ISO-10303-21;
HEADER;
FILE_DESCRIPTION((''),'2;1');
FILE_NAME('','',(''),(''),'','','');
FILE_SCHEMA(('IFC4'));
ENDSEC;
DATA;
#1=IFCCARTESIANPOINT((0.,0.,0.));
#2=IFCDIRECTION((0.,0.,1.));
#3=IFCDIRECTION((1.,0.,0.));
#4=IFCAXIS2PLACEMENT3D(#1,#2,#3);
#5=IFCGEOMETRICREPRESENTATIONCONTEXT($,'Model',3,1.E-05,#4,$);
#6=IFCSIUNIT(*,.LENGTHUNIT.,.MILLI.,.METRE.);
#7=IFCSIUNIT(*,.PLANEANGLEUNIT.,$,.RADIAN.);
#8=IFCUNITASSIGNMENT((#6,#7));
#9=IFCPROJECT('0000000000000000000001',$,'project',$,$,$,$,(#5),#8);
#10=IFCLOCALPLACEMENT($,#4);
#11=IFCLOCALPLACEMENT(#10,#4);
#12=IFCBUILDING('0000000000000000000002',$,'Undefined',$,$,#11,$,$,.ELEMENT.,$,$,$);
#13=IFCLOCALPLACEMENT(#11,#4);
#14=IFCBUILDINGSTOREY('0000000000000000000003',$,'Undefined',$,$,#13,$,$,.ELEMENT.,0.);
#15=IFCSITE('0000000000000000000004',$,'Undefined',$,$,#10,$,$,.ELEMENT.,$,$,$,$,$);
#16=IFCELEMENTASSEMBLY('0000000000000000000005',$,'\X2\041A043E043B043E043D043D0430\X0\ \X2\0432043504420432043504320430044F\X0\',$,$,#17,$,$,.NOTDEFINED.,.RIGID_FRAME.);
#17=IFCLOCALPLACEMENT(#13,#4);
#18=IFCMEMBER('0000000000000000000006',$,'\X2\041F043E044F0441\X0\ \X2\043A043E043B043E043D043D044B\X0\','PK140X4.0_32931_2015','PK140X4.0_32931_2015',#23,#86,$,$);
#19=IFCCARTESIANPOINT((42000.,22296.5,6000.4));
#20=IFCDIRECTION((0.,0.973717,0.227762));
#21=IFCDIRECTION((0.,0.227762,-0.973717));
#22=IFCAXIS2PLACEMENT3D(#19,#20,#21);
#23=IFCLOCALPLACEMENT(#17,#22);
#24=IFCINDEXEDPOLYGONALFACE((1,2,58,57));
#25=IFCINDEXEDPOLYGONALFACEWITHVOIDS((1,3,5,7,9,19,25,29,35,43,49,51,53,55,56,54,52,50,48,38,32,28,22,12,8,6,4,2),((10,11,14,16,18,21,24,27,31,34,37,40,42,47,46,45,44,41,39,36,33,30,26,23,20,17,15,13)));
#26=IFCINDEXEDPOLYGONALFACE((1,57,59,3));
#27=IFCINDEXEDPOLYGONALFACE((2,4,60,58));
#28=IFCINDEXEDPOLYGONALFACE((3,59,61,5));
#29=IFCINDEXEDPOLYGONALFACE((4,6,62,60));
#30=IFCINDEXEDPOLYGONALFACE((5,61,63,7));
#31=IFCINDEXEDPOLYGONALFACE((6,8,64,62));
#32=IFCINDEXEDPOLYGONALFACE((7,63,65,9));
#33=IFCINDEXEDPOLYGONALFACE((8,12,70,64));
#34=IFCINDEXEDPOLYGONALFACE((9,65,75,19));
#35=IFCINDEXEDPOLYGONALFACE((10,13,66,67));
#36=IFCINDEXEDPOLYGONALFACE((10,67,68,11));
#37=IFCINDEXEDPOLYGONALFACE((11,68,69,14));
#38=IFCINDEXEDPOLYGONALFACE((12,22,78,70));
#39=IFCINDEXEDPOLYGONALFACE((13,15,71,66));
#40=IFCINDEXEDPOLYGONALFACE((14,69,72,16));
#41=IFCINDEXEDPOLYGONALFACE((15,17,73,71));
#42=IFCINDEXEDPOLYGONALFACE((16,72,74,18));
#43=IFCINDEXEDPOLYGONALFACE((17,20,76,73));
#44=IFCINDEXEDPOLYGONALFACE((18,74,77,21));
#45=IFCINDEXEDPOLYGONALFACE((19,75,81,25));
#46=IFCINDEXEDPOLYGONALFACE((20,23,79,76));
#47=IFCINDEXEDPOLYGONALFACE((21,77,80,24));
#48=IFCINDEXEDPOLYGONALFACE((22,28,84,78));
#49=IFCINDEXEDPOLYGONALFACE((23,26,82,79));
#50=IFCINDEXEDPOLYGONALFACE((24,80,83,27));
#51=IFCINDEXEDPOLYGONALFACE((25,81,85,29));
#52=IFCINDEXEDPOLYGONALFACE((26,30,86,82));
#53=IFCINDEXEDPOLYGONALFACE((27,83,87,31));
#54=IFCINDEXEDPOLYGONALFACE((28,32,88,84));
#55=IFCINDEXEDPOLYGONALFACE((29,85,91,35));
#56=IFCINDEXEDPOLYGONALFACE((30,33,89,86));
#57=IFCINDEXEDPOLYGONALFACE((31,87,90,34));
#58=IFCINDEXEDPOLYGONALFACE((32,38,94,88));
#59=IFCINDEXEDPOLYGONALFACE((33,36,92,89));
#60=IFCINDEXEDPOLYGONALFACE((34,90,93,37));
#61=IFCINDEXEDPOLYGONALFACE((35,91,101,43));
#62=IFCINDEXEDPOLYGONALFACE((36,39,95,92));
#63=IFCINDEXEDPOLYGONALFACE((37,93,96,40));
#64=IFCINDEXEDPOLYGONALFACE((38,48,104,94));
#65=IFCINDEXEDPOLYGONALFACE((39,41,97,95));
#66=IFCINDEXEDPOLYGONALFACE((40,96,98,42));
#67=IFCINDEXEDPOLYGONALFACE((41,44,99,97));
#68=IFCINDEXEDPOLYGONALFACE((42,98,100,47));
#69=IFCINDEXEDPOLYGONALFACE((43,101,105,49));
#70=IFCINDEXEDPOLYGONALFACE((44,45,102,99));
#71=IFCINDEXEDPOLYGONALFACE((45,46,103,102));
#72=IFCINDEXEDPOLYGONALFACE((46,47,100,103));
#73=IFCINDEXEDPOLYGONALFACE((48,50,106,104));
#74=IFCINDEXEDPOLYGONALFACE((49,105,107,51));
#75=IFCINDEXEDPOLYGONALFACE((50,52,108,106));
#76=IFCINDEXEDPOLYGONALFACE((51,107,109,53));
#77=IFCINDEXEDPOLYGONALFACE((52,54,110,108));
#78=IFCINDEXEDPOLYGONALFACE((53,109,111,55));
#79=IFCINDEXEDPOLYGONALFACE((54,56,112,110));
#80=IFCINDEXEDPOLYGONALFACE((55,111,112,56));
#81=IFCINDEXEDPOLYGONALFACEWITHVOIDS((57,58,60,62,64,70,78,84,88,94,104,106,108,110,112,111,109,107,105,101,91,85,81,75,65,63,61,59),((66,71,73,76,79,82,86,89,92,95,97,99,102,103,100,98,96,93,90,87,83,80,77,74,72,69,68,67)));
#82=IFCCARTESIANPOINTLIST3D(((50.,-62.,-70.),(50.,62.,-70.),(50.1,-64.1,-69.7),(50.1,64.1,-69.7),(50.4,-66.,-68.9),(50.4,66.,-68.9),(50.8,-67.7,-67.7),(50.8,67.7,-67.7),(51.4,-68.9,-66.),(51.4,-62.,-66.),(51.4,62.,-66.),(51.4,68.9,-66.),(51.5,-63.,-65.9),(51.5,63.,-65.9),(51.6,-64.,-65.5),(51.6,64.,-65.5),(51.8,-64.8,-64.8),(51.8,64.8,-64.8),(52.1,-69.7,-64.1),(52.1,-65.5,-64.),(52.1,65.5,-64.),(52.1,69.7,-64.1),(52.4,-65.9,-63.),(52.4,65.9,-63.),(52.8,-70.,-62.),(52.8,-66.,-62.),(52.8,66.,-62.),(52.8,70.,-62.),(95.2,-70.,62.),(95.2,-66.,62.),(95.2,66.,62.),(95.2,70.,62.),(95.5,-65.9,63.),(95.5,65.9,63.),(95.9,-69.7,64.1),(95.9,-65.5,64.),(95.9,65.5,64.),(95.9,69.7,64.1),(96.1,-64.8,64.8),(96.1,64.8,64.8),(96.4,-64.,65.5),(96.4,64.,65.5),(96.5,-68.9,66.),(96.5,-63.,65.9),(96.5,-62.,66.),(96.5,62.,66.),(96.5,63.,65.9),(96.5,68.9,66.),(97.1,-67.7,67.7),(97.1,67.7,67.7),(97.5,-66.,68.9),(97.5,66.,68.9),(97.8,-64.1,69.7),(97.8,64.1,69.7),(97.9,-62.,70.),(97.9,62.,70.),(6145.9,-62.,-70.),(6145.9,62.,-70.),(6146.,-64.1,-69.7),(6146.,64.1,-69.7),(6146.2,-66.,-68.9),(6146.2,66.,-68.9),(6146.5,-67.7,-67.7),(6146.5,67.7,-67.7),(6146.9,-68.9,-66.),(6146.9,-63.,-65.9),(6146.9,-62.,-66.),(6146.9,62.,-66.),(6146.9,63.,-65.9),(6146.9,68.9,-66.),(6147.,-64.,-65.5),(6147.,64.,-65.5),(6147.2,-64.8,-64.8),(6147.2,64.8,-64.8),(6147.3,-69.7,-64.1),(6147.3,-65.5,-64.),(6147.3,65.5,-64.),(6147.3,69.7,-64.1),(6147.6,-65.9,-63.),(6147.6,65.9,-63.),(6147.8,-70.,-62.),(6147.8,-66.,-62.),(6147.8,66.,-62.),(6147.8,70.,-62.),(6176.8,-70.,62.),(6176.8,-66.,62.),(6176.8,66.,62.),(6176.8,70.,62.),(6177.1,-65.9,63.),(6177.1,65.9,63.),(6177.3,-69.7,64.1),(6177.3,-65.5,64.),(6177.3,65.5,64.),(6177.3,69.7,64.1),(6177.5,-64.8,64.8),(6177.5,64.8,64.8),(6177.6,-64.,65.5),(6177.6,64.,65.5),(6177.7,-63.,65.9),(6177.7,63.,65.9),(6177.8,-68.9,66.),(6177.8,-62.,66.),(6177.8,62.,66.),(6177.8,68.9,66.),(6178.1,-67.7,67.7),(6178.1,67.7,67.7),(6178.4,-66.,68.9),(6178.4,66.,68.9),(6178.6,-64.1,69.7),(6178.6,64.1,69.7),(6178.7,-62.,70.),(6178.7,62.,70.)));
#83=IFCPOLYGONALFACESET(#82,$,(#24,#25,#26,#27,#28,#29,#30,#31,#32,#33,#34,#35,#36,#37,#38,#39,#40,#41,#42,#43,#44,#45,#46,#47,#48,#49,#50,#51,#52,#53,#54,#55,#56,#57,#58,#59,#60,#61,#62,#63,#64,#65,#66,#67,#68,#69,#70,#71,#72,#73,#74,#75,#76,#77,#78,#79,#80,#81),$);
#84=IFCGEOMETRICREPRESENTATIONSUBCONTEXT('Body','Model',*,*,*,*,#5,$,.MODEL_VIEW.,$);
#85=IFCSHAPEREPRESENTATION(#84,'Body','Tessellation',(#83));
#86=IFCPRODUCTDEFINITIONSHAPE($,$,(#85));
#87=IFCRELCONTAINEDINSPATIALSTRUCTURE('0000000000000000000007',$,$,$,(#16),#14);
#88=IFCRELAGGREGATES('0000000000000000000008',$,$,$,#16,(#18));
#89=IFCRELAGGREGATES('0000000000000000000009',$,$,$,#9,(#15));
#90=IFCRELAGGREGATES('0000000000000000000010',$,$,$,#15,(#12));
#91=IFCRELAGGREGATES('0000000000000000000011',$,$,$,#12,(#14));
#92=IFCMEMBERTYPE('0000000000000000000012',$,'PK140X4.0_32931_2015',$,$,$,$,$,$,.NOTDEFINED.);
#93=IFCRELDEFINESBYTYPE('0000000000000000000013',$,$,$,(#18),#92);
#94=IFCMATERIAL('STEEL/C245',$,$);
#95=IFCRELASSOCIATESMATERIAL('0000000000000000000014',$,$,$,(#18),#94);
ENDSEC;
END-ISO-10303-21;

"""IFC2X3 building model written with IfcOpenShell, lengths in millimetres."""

from ifc_helpers import new_model, si_unit, frame, origin_with_axes, origin_2d_with_axis, place, context, subcontext, project, spatial, hollow_rectangle, extrude, clip, halfspace, material, type_object, element, aggregate, save


model = new_model("IFC2X3")

# Units and contexts
model_context = context("Model", 3, precision=1e-05, world=origin_with_axes())
body_context = subcontext(model_context, "Body", "Model", "MODEL_VIEW")
ifc_project = project(units=[si_unit("LENGTHUNIT", "METRE", prefix="MILLI"), si_unit("PLANEANGLEUNIT", "RADIAN")], contexts=[model_context])

# Site, building, storey
site_placement = place(None, origin_with_axes())
site = spatial("IfcSite", under=ifc_project, at=site_placement, Name="Undefined", CompositionType="ELEMENT")
building_placement = place(site_placement, origin_with_axes())
building = spatial("IfcBuilding", under=site, at=building_placement, Name="Undefined", CompositionType="ELEMENT")
storey_placement = place(building_placement, origin_with_axes())
storey = spatial("IfcBuildingStorey", under=building, at=storey_placement, Name="Undefined", CompositionType="ELEMENT", Elevation=0.0)

# Element assembly
ifc_material_1 = material(Name="STEEL/C245")
assembly_1_placement = place(storey_placement, origin_with_axes())
assembly_1 = element("IfcElementAssembly", 1, at=assembly_1_placement, inside=storey, Name="Колонна ветвевая", AssemblyPlace="NOTDEFINED", PredefinedType="RIGID_FRAME")

# Member
member_type_1 = type_object("IfcMemberType", Name="PK140X4.0_32931_2015", PredefinedType="NOTDEFINED")
member_1_placement = place(assembly_1_placement, frame((42000.0, 22296.5, 6000.4), z_axis=(0.0, 0.973717, 0.227762), x_axis=(0.0, 0.227762, -0.973717)))
member_1 = element("IfcMember", 2, at=member_1_placement, type_object=member_type_1, material=ifc_material_1, Name="Пояс колонны", Description="PK140X4.0_32931_2015", ObjectType="PK140X4.0_32931_2015", context=body_context, shape_type="Clipping", body=[
    clip(clip(extrude(hollow_rectangle(XDim=140.0, YDim=140.0, WallThickness=4.0, InnerFilletRadius=4.0, OuterFilletRadius=8.0, at=origin_2d_with_axis()), frame((6203.0, 0.0, 0.0), z_axis=(-1.0, 0.0, 0.0), x_axis=(0.0, -1.0, 0.0)), (0.0, 0.0, 1.0), 6169.8), halfspace(frame((6128.6, 0.0, -144.2), z_axis=(0.973717, 0.0, -0.227762), x_axis=(-0.227762, 0.0, -0.973717)), False)), halfspace(frame((33.3, 0.0, -119.0), z_axis=(-0.946221, 0.0, 0.32352), x_axis=(0.32352, 0.0, 0.946221)), False)),
])
aggregate(assembly_1, [member_1])

save(model, "model.ifc")
